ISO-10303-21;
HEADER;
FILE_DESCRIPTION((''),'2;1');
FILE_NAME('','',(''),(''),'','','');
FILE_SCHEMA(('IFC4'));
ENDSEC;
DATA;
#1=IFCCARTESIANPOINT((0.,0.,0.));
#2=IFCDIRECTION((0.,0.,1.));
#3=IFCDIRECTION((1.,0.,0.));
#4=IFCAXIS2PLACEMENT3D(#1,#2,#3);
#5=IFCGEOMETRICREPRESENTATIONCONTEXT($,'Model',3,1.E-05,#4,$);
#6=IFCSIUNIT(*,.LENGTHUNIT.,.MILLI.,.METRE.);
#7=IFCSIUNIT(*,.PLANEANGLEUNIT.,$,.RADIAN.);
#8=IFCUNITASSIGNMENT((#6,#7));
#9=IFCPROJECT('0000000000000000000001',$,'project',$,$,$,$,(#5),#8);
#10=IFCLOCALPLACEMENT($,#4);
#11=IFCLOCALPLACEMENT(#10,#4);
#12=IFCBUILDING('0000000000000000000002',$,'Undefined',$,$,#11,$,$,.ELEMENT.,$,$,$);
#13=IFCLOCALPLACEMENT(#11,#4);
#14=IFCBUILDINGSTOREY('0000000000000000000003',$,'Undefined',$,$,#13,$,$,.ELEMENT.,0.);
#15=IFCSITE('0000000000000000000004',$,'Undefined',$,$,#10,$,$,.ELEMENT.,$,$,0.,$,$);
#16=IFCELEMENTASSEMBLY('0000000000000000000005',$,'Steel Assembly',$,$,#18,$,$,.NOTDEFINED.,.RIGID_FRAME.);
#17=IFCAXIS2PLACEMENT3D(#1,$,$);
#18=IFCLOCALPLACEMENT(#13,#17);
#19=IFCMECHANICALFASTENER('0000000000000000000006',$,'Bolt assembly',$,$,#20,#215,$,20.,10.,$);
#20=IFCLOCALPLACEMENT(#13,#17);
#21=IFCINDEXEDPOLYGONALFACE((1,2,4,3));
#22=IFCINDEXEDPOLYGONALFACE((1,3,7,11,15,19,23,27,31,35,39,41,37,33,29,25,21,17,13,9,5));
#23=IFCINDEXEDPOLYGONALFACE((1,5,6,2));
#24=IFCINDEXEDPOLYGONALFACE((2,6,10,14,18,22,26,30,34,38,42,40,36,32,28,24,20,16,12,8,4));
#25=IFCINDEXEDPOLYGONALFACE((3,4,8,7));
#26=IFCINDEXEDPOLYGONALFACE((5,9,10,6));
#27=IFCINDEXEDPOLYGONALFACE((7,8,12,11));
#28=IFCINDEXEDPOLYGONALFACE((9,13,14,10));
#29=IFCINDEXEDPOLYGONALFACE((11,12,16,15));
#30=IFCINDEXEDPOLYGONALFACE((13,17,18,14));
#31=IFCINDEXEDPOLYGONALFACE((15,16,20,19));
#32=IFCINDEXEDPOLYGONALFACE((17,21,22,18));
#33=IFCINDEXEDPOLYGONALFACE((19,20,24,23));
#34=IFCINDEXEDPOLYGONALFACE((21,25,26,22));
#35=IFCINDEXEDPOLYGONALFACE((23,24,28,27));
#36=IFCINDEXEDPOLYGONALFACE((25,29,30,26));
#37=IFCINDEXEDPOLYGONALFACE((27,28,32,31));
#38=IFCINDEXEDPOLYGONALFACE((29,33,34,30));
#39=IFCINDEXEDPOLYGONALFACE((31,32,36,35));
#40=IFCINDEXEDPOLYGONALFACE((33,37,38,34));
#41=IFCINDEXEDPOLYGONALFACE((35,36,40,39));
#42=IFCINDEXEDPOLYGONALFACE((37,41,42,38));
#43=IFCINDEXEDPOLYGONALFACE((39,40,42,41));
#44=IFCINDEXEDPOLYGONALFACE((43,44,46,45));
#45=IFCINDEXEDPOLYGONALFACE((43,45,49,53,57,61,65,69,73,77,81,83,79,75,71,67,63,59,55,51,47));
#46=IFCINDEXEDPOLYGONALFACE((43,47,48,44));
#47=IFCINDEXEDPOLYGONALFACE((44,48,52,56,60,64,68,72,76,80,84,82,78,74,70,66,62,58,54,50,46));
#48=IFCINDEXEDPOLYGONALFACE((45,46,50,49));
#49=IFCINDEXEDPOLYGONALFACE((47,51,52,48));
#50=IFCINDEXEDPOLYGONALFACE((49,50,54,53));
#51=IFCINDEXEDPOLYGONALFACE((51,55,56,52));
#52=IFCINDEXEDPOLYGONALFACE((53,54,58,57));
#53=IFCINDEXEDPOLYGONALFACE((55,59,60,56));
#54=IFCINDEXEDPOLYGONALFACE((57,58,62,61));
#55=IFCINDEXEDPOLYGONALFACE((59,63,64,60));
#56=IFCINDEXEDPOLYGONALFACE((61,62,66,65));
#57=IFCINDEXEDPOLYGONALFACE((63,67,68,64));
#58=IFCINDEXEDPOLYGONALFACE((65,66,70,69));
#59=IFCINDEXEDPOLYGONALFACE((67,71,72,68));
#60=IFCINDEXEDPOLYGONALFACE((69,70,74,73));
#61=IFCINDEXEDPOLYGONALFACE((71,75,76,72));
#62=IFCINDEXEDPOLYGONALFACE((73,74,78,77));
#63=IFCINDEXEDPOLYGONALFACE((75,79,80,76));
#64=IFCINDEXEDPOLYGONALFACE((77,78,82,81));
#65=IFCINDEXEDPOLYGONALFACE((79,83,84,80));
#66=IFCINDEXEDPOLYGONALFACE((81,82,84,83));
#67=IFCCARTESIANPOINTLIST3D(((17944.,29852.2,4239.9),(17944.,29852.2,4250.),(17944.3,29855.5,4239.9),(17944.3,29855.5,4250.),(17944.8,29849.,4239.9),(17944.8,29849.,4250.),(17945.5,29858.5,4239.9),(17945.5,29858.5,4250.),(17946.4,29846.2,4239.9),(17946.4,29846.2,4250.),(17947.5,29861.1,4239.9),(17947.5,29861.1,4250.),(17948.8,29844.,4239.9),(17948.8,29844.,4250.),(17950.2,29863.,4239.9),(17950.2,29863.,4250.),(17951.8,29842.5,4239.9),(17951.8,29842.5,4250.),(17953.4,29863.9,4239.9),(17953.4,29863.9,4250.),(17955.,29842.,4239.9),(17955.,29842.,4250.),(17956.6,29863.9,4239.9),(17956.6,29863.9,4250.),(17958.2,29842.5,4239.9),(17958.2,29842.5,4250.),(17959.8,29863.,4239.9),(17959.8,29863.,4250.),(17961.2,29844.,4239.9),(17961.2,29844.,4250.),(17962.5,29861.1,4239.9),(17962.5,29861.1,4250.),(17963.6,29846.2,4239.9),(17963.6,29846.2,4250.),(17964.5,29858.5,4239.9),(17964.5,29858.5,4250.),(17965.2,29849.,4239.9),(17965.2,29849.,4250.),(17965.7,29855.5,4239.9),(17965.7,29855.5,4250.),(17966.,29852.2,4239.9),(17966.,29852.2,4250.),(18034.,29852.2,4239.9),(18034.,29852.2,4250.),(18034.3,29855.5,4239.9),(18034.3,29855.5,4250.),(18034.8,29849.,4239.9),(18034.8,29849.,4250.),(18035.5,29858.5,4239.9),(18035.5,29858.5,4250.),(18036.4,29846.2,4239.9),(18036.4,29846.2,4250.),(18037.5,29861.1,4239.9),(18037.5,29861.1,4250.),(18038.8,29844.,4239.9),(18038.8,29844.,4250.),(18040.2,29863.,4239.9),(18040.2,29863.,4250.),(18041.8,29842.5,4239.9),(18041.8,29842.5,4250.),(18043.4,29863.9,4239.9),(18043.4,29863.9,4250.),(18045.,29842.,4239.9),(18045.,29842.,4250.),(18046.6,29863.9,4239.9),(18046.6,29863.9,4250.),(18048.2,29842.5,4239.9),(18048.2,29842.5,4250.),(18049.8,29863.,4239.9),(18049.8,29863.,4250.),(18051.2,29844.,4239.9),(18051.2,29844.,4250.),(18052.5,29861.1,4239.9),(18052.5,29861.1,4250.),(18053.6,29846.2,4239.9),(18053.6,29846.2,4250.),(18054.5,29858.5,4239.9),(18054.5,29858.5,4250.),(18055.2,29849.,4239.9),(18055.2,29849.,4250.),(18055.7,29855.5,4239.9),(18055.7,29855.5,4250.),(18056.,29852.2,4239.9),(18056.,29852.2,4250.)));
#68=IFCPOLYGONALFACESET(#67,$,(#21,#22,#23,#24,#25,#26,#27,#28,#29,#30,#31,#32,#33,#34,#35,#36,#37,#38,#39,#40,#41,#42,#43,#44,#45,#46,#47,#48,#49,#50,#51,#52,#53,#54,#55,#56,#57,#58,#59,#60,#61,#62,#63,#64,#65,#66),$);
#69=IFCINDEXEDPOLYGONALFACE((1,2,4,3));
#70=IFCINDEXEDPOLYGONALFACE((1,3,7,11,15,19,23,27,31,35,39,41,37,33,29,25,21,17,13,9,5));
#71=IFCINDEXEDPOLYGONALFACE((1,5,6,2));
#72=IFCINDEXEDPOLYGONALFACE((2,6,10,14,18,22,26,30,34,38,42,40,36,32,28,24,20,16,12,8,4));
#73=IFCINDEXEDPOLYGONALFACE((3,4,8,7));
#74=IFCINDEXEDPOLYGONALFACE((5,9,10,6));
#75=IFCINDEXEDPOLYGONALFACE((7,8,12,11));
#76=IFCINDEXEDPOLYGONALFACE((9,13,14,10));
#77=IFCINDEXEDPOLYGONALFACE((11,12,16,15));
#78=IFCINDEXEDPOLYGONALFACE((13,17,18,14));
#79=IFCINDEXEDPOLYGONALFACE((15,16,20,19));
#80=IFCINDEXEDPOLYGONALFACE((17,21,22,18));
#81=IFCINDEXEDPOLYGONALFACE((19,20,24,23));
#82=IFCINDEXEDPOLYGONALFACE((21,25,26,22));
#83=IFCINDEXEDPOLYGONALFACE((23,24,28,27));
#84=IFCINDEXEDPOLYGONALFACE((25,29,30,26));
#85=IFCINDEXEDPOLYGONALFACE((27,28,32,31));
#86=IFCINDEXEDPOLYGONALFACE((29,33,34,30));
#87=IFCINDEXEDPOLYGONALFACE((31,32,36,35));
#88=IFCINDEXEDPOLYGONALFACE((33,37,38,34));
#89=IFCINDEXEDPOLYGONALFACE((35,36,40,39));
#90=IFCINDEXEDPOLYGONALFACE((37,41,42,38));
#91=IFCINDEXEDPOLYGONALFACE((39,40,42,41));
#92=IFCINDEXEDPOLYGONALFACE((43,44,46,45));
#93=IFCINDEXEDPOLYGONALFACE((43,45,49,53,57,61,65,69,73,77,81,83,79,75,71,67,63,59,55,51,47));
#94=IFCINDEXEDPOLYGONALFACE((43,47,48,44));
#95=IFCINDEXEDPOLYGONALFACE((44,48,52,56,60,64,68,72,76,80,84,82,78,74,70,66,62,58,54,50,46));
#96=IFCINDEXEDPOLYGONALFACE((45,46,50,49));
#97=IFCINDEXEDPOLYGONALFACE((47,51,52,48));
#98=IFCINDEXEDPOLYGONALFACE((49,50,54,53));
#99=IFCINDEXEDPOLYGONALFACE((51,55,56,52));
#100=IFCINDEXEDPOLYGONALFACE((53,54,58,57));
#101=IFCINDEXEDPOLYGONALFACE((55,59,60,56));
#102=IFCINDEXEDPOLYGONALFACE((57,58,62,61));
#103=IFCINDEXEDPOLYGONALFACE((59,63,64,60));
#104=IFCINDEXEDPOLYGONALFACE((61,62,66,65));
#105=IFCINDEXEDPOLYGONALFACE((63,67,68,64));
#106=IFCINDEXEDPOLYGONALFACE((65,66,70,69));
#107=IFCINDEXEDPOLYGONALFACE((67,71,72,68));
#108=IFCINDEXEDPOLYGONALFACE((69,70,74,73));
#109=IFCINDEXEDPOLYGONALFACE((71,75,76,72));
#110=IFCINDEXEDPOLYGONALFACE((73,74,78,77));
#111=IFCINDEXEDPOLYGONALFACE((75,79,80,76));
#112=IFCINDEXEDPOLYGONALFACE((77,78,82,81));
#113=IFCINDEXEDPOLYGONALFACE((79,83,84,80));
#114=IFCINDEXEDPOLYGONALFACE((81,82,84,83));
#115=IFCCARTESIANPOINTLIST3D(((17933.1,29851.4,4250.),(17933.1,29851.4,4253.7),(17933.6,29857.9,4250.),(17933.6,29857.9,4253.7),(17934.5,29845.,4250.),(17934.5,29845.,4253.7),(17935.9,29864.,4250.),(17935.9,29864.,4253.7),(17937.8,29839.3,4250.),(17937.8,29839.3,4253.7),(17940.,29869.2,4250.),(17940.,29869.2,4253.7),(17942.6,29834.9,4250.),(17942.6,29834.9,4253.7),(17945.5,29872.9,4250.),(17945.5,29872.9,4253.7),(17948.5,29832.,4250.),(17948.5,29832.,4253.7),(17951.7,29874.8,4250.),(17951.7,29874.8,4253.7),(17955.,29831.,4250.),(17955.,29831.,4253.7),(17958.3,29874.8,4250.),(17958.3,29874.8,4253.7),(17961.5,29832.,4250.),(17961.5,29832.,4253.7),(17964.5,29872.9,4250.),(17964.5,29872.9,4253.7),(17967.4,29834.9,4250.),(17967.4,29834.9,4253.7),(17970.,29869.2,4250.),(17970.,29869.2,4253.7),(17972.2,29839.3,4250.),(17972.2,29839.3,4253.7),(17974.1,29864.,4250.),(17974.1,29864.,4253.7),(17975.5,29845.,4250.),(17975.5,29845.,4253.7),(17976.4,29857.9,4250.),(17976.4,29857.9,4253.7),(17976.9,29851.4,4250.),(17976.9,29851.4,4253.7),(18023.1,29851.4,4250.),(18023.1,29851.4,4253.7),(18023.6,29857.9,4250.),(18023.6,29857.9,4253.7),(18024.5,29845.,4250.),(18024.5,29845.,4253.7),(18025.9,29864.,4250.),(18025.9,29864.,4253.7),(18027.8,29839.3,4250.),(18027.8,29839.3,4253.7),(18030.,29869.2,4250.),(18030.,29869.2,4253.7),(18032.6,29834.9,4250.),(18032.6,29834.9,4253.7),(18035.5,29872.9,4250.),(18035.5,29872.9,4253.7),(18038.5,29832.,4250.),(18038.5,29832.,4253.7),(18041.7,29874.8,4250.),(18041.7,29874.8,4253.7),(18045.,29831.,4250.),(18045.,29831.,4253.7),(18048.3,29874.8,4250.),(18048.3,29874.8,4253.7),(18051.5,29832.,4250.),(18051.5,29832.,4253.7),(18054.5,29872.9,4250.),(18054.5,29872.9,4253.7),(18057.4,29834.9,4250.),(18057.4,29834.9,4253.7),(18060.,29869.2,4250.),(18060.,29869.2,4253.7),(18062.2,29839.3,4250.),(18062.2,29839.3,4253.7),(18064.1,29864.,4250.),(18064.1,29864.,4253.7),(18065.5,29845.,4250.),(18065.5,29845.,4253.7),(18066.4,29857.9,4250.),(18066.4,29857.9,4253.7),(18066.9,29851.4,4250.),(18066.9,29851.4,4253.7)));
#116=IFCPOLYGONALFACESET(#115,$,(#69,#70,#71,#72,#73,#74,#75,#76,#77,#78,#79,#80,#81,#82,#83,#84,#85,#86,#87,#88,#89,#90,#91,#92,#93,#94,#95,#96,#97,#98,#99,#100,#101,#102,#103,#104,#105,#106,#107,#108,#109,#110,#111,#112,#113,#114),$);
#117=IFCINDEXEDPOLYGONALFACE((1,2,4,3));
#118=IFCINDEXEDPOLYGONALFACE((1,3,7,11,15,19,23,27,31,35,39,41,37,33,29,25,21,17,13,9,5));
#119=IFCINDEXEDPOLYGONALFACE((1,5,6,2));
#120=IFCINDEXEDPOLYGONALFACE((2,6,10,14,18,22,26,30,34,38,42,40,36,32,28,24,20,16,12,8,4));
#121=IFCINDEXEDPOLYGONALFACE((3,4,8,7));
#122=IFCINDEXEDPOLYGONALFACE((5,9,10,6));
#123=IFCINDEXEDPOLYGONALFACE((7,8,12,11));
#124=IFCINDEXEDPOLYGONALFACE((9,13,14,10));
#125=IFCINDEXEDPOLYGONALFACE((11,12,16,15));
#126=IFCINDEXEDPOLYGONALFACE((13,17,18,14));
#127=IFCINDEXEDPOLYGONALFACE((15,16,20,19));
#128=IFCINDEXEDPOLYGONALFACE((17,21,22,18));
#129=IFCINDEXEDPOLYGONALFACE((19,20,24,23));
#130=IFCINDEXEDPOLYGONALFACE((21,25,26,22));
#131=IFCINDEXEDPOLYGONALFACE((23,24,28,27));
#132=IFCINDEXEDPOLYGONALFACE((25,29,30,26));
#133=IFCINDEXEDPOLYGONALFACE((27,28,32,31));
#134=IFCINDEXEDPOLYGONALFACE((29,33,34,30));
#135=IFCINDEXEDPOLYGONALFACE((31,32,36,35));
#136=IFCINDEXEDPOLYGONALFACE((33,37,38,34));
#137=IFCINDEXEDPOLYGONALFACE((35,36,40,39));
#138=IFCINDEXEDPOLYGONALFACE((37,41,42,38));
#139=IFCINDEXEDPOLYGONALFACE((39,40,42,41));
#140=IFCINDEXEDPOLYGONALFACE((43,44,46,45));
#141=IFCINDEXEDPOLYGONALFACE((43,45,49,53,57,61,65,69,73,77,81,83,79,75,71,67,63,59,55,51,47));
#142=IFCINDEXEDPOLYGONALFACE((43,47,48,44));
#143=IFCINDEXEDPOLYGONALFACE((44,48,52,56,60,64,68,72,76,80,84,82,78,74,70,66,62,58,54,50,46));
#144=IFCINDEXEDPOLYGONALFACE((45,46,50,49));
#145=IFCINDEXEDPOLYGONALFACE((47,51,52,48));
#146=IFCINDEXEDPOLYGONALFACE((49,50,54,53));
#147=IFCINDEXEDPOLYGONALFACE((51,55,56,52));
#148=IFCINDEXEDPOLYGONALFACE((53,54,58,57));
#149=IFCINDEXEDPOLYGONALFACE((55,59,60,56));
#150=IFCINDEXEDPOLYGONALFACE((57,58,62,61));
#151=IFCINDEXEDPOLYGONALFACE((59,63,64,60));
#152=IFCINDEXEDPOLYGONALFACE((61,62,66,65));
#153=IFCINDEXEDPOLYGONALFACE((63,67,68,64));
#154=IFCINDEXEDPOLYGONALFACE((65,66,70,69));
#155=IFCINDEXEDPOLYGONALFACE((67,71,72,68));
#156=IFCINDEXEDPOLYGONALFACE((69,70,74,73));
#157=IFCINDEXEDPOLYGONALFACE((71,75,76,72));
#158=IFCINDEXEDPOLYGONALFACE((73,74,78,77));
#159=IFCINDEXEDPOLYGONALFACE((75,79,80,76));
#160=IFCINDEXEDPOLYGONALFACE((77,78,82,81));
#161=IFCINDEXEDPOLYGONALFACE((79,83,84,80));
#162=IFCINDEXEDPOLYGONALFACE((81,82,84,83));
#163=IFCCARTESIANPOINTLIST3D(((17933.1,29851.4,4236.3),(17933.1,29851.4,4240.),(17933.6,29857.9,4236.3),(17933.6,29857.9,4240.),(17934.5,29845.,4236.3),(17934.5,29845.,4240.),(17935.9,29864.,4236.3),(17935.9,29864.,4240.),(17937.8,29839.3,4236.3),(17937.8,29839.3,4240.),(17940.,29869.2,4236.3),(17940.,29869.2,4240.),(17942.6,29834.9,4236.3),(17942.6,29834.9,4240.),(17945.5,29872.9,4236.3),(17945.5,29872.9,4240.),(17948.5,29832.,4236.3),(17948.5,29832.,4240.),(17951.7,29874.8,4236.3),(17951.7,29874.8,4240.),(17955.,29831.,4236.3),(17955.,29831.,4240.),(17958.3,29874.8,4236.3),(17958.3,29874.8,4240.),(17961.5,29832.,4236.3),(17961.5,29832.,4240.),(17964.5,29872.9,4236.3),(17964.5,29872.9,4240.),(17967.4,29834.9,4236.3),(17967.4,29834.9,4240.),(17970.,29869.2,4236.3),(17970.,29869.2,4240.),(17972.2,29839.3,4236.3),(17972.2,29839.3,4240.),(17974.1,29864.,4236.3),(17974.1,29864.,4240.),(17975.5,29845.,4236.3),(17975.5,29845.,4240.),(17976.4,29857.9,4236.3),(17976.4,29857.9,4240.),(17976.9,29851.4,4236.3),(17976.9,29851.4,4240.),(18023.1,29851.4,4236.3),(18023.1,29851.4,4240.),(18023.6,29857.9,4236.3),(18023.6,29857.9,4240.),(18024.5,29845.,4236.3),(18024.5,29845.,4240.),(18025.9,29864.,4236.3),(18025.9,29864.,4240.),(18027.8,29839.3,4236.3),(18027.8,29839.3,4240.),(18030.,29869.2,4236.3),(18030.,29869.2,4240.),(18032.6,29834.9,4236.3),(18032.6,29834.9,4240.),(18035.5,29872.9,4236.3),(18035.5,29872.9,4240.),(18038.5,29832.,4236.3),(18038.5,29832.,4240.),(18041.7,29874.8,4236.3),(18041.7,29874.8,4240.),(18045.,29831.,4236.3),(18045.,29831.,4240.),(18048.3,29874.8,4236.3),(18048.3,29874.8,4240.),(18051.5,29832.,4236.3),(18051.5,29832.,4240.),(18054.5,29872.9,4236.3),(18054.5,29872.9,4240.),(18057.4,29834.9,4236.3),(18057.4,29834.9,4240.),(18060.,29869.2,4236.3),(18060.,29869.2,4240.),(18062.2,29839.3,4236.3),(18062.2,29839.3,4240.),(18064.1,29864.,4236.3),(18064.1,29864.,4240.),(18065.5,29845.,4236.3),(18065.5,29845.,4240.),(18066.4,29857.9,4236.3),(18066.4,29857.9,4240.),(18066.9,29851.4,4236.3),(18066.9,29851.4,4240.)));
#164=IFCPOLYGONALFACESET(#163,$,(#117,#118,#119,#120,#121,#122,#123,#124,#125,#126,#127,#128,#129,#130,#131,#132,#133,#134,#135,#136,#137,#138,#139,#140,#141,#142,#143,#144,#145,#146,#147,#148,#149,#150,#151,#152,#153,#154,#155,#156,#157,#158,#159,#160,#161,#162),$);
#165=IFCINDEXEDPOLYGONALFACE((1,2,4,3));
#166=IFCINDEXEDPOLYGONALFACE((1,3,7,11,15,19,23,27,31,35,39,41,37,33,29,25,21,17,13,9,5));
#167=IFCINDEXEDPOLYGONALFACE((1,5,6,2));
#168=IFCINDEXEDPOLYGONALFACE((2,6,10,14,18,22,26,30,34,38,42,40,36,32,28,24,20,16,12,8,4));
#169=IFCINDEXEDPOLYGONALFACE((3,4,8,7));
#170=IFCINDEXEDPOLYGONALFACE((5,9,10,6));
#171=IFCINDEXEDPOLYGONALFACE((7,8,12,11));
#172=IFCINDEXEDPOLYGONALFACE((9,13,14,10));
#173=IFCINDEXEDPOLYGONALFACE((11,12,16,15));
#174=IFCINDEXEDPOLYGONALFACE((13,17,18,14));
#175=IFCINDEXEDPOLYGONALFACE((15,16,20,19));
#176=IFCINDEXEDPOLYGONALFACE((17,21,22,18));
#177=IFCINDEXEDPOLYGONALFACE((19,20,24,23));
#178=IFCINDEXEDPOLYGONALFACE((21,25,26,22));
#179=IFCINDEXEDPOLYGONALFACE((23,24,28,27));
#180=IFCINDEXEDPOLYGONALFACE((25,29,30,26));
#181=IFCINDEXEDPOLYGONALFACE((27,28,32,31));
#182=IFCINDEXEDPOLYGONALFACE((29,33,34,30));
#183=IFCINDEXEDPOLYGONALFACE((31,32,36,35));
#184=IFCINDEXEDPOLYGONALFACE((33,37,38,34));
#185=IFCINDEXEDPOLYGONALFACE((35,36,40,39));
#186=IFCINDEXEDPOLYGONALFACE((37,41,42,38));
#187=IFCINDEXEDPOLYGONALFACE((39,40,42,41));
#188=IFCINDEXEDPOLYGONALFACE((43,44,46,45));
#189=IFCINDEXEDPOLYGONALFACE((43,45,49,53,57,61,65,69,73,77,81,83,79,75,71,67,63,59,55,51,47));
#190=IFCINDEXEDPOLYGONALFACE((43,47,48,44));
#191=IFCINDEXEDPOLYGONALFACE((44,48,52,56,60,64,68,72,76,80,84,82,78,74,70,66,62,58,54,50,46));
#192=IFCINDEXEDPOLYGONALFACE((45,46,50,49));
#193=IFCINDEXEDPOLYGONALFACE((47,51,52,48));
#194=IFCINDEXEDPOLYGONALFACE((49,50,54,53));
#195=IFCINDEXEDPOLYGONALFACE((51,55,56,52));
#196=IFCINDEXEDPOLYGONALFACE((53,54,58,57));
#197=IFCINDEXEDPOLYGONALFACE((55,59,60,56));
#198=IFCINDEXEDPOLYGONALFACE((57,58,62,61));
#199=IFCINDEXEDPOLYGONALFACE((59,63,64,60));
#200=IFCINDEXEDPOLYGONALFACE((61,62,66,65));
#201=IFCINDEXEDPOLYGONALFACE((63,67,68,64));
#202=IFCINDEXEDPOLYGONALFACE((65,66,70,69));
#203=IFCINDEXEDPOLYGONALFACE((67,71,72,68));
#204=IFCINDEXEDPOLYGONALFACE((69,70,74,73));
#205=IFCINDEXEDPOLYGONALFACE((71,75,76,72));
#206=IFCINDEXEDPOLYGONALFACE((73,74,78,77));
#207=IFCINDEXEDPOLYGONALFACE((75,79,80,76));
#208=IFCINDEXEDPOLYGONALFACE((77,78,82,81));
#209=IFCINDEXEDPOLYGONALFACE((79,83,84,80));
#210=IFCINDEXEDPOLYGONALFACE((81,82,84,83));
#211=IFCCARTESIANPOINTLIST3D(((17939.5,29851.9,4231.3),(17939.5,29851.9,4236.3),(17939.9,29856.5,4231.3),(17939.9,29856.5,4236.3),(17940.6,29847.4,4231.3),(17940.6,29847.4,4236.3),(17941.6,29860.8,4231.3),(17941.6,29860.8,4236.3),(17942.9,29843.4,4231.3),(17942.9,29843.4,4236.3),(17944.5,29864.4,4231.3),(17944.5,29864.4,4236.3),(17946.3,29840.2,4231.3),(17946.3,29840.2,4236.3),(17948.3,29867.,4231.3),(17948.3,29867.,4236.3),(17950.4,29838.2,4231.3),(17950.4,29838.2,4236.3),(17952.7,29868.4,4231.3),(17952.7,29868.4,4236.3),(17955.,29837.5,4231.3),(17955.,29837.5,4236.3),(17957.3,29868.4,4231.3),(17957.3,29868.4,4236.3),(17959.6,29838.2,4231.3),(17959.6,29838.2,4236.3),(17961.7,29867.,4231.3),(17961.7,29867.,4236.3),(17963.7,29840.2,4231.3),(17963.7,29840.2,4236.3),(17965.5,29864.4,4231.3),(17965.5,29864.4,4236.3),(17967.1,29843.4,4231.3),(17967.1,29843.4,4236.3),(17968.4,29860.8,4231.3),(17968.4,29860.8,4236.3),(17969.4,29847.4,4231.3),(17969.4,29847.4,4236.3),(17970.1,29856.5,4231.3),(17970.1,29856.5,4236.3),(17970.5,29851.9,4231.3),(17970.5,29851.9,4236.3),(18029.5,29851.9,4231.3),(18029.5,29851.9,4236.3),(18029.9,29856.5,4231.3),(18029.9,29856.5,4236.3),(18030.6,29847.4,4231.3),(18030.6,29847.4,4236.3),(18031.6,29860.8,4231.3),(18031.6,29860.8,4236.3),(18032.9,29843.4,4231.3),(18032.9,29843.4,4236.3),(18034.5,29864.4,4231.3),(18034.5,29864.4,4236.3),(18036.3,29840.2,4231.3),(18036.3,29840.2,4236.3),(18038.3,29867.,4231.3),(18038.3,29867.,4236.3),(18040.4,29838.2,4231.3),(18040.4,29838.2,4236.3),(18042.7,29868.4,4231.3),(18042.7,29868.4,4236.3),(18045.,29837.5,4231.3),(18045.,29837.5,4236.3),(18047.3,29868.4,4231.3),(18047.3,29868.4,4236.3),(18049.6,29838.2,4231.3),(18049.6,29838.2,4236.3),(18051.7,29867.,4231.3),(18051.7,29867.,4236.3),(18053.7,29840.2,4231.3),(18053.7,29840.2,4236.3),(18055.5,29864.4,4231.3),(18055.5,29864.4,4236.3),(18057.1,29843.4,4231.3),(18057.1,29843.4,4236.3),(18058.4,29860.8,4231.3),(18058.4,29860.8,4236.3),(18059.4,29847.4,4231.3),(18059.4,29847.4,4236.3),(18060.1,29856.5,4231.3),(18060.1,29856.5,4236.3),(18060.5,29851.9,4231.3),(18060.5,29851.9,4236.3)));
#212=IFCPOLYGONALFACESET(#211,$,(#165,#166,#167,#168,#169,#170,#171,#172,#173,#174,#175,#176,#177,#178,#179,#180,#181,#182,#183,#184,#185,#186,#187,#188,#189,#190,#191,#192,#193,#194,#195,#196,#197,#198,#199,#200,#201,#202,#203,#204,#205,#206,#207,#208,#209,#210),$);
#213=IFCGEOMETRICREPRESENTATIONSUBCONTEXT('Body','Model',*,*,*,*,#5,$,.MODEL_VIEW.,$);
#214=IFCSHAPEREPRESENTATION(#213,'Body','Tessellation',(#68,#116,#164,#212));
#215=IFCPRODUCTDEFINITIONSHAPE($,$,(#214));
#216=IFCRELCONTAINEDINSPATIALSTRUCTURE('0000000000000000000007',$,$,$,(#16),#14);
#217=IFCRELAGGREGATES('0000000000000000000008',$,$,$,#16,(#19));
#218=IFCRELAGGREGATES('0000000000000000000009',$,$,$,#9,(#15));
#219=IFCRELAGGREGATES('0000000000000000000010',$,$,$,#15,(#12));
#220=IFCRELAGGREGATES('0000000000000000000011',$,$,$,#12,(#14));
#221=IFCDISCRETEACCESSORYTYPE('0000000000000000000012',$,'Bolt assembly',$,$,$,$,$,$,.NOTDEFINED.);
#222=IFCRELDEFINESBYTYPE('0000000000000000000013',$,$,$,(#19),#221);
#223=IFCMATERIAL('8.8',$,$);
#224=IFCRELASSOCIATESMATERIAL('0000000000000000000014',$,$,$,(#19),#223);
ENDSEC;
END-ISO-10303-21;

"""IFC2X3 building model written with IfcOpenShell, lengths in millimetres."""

from ifc_helpers import new_model, si_unit, frame, origin_with_axes, origin_2d_with_axis, place, context, subcontext, project, spatial, circle, extrude, source, transform, mapped, material, type_object, element, aggregate, save


model = new_model("IFC2X3")

# Units and contexts
model_context = context("Model", 3, precision=1e-05, world=origin_with_axes())
body_context = subcontext(model_context, "Body", "Model", "MODEL_VIEW")
ifc_project = project(units=[si_unit("LENGTHUNIT", "METRE", prefix="MILLI"), si_unit("PLANEANGLEUNIT", "RADIAN")], contexts=[model_context])

# Site, building, storey
site_placement = place(None, origin_with_axes())
site = spatial("IfcSite", under=ifc_project, at=site_placement, Name="Undefined", CompositionType="ELEMENT", RefElevation=0.0)
building_placement = place(site_placement, origin_with_axes())
building = spatial("IfcBuilding", under=site, at=building_placement, Name="Undefined", CompositionType="ELEMENT")
storey_placement = place(building_placement, origin_with_axes())
storey = spatial("IfcBuildingStorey", under=building, at=storey_placement, Name="Undefined", CompositionType="ELEMENT", Elevation=0.0)

# Element assembly
assembly_1_placement = place(storey_placement, origin_with_axes())
assembly_1 = element("IfcElementAssembly", 1, at=assembly_1_placement, inside=storey, Name="Steel Assembly", AssemblyPlace="NOTDEFINED", PredefinedType="RIGID_FRAME")

# Shared definitions
ifc_material_1 = material(Name="8.8")
discrete_accessory_type_1 = type_object("IfcDiscreteAccessoryType", Name="Bolt assembly")

# Mechanical fastener
shared_shape_1 = source(origin_with_axes(), body_context, "Body", "SweptSolid", [
    extrude(circle(Radius=11.0, at=origin_2d_with_axis()), frame((0.0, -10.0, 0.0), z_axis=(0.0, 1.0, 0.0), x_axis=(1.0, 0.0, 0.0)), (0.0, 0.0, 1.0), 10.1),
    extrude(circle(Radius=22.0, at=origin_2d_with_axis()), frame((0.0, -13.7, 0.0), z_axis=(0.0, 1.0, 0.0), x_axis=(1.0, 0.0, 0.0)), (0.0, 0.0, 1.0), 3.7),
    extrude(circle(Radius=22.0, at=origin_2d_with_axis()), frame((0.0, 0.0, 0.0), z_axis=(0.0, 1.0, 0.0), x_axis=(1.0, 0.0, 0.0)), (0.0, 0.0, 1.0), 3.7),
    extrude(circle(Radius=15.5, at=origin_2d_with_axis()), frame((0.0, 3.7, 0.0), z_axis=(0.0, 1.0, 0.0), x_axis=(1.0, 0.0, 0.0)), (0.0, 0.0, 1.0), 5.0),
])
mechanical_fastener_1_placement = place(assembly_1_placement, frame((18000.0, 29853.0, 4240.0), z_axis=(1.0, 0.0, 0.0), x_axis=(0.0, -1.0, 0.0)))
mechanical_fastener_1 = element("IfcMechanicalFastener", 2, at=mechanical_fastener_1_placement, type_object=discrete_accessory_type_1, material=ifc_material_1, Name="Bolt assembly", NominalDiameter=20.0, NominalLength=10.0, context=body_context, shape_type="MappedRepresentation", body=[
    mapped(shared_shape_1, transform((0.0, 0.0, 45.0))),
    mapped(shared_shape_1, transform((0.0, 0.0, -45.0))),
])
aggregate(assembly_1, [mechanical_fastener_1])

save(model, "model.ifc")
